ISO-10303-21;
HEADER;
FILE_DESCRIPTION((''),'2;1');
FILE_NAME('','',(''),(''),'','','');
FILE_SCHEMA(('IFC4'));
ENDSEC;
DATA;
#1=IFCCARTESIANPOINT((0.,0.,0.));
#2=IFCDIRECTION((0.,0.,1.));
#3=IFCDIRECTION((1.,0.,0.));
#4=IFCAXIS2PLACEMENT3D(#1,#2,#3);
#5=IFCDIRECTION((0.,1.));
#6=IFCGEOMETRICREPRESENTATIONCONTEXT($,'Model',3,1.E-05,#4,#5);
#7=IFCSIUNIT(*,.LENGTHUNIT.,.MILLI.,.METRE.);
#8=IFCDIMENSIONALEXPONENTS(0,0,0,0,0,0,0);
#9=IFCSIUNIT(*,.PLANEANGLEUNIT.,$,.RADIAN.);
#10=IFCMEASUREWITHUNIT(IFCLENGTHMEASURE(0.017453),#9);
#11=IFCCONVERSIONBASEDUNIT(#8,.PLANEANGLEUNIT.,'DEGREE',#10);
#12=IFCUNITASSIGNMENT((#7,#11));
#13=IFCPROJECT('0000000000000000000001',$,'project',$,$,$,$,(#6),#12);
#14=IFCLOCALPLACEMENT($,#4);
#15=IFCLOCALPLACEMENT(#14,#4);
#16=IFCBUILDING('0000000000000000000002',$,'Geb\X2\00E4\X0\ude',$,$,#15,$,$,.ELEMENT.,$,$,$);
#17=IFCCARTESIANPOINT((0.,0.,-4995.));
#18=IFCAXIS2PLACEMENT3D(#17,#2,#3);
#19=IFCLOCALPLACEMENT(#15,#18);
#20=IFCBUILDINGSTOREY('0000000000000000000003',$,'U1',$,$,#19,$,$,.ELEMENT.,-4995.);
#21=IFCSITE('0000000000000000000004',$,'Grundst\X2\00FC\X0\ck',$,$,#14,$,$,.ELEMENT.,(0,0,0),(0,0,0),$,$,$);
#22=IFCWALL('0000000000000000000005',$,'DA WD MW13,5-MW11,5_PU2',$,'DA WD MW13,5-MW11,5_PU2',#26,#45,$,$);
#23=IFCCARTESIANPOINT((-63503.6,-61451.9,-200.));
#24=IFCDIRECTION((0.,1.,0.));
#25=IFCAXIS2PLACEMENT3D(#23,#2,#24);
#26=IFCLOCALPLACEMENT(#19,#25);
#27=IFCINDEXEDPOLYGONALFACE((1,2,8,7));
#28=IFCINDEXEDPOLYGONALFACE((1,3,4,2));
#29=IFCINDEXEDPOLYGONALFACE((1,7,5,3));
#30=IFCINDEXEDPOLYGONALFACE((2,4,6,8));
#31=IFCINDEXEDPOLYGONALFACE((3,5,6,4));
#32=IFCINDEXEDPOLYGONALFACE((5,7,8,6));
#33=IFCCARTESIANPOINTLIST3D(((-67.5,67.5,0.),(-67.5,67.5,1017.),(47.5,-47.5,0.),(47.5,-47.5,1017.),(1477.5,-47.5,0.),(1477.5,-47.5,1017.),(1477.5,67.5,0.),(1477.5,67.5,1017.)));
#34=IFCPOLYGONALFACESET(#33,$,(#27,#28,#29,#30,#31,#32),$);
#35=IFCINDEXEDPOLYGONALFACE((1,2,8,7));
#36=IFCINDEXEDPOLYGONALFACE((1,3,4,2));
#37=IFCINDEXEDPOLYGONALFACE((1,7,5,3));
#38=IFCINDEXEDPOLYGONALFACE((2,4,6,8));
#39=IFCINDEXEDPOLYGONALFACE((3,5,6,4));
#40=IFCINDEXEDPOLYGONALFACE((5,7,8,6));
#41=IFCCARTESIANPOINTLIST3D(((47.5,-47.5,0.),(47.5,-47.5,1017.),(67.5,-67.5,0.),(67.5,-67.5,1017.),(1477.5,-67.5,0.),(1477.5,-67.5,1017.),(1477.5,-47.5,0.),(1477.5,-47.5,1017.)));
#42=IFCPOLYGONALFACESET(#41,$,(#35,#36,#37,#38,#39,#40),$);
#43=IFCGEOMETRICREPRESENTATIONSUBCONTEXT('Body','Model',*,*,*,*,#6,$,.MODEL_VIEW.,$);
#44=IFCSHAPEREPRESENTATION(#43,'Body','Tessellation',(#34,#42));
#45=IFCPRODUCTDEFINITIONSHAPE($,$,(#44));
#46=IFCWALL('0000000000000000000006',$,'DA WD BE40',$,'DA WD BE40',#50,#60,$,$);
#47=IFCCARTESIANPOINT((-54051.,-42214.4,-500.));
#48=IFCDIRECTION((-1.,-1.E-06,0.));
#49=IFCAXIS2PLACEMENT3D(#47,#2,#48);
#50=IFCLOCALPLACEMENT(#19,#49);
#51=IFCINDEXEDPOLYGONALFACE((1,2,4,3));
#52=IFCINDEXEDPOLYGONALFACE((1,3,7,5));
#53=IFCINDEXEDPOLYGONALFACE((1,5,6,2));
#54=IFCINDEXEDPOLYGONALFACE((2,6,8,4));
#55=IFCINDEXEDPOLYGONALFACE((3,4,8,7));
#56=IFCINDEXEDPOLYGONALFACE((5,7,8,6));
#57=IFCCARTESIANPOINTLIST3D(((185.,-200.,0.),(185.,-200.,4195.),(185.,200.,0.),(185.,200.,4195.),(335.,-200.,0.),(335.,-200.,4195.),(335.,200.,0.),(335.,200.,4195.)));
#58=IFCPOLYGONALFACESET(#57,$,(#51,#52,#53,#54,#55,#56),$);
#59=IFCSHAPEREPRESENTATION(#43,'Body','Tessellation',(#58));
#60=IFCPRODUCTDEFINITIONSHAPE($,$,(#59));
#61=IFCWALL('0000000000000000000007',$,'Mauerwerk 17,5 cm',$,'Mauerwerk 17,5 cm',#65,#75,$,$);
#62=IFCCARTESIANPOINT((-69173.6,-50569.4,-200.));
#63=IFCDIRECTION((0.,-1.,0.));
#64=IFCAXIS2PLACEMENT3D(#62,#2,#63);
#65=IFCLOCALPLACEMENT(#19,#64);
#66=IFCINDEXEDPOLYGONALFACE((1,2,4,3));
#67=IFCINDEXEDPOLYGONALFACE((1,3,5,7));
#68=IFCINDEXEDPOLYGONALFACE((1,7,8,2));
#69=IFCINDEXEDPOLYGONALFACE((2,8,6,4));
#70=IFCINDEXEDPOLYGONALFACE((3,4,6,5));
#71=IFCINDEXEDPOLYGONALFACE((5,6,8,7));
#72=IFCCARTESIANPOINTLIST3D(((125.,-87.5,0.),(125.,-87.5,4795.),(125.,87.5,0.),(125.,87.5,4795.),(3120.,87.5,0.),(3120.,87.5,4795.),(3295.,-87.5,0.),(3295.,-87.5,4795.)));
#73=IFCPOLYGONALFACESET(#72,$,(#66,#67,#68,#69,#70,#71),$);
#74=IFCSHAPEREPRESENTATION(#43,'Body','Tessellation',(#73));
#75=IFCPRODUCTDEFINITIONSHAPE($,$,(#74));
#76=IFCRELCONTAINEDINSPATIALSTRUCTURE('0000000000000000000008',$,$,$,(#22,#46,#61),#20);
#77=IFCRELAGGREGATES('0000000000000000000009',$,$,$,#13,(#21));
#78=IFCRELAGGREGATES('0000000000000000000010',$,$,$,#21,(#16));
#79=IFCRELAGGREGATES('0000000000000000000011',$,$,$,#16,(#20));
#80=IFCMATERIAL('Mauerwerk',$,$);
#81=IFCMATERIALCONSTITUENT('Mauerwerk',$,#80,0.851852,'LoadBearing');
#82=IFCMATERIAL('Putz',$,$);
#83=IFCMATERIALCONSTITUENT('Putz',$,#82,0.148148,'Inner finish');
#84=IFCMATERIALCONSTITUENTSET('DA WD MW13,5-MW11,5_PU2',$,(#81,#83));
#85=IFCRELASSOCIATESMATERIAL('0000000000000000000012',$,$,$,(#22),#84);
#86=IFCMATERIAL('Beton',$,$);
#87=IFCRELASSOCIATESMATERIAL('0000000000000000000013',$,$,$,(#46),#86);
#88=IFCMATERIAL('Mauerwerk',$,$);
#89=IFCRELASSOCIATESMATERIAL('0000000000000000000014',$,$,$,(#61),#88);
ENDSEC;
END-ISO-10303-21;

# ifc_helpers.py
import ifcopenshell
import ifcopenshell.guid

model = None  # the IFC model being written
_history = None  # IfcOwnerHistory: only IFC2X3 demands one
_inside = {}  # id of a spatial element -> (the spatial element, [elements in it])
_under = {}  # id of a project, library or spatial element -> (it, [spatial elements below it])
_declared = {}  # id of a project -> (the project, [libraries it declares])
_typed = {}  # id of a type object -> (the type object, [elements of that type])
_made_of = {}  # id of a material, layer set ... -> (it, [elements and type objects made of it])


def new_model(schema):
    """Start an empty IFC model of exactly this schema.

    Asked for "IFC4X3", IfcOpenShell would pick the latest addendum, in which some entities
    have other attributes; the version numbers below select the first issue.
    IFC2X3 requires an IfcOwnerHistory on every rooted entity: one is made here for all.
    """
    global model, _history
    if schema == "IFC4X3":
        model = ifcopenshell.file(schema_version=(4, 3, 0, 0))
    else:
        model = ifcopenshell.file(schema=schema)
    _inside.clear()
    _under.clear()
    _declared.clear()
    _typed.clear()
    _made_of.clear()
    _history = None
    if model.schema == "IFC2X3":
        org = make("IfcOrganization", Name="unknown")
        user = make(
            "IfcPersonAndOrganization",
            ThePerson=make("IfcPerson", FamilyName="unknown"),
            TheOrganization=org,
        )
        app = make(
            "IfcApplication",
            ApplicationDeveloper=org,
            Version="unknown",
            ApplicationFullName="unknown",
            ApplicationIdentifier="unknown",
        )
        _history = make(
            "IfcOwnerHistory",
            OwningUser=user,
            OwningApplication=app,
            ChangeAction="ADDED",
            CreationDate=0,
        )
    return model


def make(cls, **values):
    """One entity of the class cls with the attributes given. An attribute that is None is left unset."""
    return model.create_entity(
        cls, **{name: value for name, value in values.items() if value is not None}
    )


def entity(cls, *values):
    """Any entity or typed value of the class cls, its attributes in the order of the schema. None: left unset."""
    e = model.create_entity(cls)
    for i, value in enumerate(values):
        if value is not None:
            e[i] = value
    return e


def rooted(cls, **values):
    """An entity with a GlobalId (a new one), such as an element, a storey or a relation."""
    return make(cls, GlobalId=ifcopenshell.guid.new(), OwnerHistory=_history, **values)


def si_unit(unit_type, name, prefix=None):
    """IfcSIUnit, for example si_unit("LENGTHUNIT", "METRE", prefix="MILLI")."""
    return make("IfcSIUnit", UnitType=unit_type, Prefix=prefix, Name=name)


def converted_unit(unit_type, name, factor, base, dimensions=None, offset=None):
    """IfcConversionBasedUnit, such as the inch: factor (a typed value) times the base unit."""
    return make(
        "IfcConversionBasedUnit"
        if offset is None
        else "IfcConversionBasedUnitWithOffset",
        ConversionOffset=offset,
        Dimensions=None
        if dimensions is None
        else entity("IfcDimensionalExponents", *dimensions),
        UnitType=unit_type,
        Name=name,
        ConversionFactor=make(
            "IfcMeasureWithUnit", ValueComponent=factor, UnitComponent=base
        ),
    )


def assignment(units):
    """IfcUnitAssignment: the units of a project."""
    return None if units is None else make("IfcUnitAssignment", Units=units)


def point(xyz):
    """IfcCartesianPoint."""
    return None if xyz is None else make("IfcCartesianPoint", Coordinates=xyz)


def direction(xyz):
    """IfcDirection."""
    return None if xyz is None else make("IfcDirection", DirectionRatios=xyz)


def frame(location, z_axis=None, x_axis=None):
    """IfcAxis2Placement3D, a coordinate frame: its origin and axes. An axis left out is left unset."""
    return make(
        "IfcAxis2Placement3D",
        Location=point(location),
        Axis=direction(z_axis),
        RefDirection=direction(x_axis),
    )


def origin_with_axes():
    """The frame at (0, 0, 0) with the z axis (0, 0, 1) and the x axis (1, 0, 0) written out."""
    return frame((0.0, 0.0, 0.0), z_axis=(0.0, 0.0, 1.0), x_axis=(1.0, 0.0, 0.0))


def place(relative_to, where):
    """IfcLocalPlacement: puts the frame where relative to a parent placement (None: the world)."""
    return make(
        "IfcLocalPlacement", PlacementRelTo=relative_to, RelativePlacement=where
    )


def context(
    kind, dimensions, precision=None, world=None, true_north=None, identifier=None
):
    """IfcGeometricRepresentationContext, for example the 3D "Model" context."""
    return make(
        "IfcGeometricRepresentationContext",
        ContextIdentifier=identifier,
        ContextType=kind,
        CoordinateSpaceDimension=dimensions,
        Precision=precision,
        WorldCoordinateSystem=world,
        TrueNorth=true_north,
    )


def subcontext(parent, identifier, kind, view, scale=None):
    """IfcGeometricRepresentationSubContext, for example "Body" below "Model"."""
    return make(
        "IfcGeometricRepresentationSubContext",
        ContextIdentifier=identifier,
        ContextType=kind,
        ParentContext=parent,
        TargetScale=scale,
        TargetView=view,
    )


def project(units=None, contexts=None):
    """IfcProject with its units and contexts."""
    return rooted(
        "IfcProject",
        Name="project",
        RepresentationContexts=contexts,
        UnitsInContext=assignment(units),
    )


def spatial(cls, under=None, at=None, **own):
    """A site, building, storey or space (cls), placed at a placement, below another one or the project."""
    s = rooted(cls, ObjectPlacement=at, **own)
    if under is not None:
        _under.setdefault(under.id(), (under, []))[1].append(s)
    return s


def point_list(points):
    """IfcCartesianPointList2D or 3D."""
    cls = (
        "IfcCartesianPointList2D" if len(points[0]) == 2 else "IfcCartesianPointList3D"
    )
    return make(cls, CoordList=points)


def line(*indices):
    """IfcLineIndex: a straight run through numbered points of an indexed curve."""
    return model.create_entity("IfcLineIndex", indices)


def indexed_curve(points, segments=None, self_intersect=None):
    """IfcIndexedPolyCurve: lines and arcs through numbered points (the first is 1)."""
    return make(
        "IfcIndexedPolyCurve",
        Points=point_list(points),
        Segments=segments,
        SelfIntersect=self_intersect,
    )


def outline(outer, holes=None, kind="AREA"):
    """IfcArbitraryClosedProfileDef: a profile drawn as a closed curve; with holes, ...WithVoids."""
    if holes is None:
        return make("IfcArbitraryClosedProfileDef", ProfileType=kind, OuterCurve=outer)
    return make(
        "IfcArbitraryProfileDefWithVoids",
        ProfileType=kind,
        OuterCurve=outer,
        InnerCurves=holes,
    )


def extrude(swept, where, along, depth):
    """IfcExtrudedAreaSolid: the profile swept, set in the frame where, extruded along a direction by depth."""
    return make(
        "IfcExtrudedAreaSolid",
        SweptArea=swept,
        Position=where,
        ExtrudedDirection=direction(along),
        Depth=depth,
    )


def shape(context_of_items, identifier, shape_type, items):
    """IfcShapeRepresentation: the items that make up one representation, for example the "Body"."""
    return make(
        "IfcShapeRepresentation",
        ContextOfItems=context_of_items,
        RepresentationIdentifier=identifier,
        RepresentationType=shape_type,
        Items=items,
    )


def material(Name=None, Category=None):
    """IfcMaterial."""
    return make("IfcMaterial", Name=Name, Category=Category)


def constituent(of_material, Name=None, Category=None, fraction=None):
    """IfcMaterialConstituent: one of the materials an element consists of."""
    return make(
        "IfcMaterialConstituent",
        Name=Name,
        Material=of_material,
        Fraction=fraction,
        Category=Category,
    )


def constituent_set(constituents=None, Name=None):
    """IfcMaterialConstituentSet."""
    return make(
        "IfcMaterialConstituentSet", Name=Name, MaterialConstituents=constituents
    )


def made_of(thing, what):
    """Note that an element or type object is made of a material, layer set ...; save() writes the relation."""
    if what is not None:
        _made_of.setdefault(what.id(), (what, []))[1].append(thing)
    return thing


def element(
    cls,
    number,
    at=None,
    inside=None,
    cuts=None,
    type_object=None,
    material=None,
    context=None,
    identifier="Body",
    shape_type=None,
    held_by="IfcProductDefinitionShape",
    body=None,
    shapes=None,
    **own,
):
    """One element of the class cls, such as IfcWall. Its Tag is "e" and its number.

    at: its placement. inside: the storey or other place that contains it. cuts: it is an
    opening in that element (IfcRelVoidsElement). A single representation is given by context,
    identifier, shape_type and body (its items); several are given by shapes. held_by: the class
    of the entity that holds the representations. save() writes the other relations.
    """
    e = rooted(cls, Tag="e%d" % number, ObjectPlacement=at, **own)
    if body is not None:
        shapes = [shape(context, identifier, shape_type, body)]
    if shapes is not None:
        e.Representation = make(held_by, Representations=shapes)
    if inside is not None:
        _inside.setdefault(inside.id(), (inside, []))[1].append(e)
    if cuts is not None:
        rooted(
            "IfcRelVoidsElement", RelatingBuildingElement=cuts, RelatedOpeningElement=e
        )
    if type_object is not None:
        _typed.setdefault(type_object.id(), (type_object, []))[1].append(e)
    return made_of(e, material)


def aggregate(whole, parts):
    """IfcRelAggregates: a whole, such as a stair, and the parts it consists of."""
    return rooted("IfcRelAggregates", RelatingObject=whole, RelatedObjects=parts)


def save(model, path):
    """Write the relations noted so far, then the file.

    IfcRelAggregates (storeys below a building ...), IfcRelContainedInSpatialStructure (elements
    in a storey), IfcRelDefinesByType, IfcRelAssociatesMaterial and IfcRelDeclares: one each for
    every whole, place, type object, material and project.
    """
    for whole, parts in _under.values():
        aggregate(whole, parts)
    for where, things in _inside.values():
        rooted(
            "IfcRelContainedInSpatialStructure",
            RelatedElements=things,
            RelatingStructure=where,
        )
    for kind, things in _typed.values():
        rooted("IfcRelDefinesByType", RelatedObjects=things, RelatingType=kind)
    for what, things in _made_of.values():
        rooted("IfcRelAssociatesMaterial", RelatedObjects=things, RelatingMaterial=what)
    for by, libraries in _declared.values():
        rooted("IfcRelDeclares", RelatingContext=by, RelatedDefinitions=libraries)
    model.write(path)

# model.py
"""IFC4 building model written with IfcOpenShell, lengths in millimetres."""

from ifc_helpers import new_model, entity, si_unit, converted_unit, direction, frame, origin_with_axes, place, context, subcontext, project, spatial, line, indexed_curve, outline, extrude, material, constituent, constituent_set, element, save


model = new_model("IFC4")

# Units and contexts
model_context = context("Model", 3, precision=1e-05, world=origin_with_axes(), true_north=direction((0.0, 1.0)))
body_context = subcontext(model_context, "Body", "Model", "MODEL_VIEW")
ifc_project = project(units=[si_unit("LENGTHUNIT", "METRE", prefix="MILLI"), converted_unit("PLANEANGLEUNIT", "DEGREE", entity("IfcLengthMeasure", 0.017453), si_unit("PLANEANGLEUNIT", "RADIAN"), dimensions=[0, 0, 0, 0, 0, 0, 0])], contexts=[model_context])

# Site, building, storey
site_placement = place(None, origin_with_axes())
site = spatial("IfcSite", under=ifc_project, at=site_placement, Name="Grundstück", CompositionType="ELEMENT", RefLatitude=(0, 0, 0), RefLongitude=(0, 0, 0))
building_placement = place(site_placement, origin_with_axes())
building = spatial("IfcBuilding", under=site, at=building_placement, Name="Gebäude", CompositionType="ELEMENT")
storey_placement = place(building_placement, frame((0.0, 0.0, -4995.0), z_axis=(0.0, 0.0, 1.0), x_axis=(1.0, 0.0, 0.0)))
storey = spatial("IfcBuildingStorey", under=building, at=storey_placement, Name="U1", CompositionType="ELEMENT", Elevation=-4995.0)

# Walls
ifc_material_1 = material(Name="Mauerwerk")
ifc_constituent_1 = constituent(ifc_material_1, Name="Mauerwerk", Category="LoadBearing", fraction=0.851852)
ifc_material_2 = material(Name="Putz")
ifc_constituent_2 = constituent(ifc_material_2, Name="Putz", Category="Inner finish", fraction=0.148148)
ifc_constituent_set_1 = constituent_set(constituents=[ifc_constituent_1, ifc_constituent_2], Name="DA WD MW13,5-MW11,5_PU2")
wall_1_placement = place(storey_placement, frame((-63503.6, -61451.9, -200.0), z_axis=(0.0, 0.0, 1.0), x_axis=(0.0, 1.0, 0.0)))
element("IfcWall", 1, at=wall_1_placement, inside=storey, material=ifc_constituent_set_1, Name="DA WD MW13,5-MW11,5_PU2", ObjectType="DA WD MW13,5-MW11,5_PU2", context=body_context, shape_type="SweptSolid", body=[
    extrude(outline(indexed_curve([(1477.5, 67.5), (1477.5, -47.5), (47.5, -47.5), (-67.5, 67.5)], segments=[line(1, 2), line(2, 3), line(3, 4), line(4, 1)])), origin_with_axes(), (0.0, 0.0, 1.0), 1017.0),
    extrude(outline(indexed_curve([(1477.5, -47.5), (1477.5, -67.5), (67.5, -67.5), (47.5, -47.5)], segments=[line(1, 2), line(2, 3), line(3, 4), line(4, 1)])), origin_with_axes(), (0.0, 0.0, 1.0), 1017.0),
])
ifc_material_3 = material(Name="Beton")
wall_2_placement = place(storey_placement, frame((-54051.0, -42214.4, -500.0), z_axis=(0.0, 0.0, 1.0), x_axis=(-1.0, -0.000001, 0.0)))
element("IfcWall", 2, at=wall_2_placement, inside=storey, material=ifc_material_3, Name="DA WD BE40", ObjectType="DA WD BE40", context=body_context, shape_type="SweptSolid", body=[
    extrude(outline(indexed_curve([(185.0, -200.0), (185.0, 200.0), (335.0, 200.0), (335.0, -200.0)], segments=[line(1, 2), line(2, 3), line(3, 4), line(4, 1)])), origin_with_axes(), (0.0, 0.0, 1.0), 4195.0),
])
ifc_material_4 = material(Name="Mauerwerk")
wall_3_placement = place(storey_placement, frame((-69173.6, -50569.4, -200.0), z_axis=(0.0, 0.0, 1.0), x_axis=(0.0, -1.0, 0.0)))
element("IfcWall", 3, at=wall_3_placement, inside=storey, material=ifc_material_4, Name="Mauerwerk 17,5 cm", ObjectType="Mauerwerk 17,5 cm", context=body_context, shape_type="SweptSolid", body=[
    extrude(outline(indexed_curve([(3120.0, 87.5), (125.0, 87.5), (125.0, -87.5), (3295.0, -87.5)], segments=[line(1, 2), line(2, 3), line(3, 4), line(4, 1)])), origin_with_axes(), (0.0, 0.0, 1.0), 4795.0),
])

save(model, "model.ifc")
